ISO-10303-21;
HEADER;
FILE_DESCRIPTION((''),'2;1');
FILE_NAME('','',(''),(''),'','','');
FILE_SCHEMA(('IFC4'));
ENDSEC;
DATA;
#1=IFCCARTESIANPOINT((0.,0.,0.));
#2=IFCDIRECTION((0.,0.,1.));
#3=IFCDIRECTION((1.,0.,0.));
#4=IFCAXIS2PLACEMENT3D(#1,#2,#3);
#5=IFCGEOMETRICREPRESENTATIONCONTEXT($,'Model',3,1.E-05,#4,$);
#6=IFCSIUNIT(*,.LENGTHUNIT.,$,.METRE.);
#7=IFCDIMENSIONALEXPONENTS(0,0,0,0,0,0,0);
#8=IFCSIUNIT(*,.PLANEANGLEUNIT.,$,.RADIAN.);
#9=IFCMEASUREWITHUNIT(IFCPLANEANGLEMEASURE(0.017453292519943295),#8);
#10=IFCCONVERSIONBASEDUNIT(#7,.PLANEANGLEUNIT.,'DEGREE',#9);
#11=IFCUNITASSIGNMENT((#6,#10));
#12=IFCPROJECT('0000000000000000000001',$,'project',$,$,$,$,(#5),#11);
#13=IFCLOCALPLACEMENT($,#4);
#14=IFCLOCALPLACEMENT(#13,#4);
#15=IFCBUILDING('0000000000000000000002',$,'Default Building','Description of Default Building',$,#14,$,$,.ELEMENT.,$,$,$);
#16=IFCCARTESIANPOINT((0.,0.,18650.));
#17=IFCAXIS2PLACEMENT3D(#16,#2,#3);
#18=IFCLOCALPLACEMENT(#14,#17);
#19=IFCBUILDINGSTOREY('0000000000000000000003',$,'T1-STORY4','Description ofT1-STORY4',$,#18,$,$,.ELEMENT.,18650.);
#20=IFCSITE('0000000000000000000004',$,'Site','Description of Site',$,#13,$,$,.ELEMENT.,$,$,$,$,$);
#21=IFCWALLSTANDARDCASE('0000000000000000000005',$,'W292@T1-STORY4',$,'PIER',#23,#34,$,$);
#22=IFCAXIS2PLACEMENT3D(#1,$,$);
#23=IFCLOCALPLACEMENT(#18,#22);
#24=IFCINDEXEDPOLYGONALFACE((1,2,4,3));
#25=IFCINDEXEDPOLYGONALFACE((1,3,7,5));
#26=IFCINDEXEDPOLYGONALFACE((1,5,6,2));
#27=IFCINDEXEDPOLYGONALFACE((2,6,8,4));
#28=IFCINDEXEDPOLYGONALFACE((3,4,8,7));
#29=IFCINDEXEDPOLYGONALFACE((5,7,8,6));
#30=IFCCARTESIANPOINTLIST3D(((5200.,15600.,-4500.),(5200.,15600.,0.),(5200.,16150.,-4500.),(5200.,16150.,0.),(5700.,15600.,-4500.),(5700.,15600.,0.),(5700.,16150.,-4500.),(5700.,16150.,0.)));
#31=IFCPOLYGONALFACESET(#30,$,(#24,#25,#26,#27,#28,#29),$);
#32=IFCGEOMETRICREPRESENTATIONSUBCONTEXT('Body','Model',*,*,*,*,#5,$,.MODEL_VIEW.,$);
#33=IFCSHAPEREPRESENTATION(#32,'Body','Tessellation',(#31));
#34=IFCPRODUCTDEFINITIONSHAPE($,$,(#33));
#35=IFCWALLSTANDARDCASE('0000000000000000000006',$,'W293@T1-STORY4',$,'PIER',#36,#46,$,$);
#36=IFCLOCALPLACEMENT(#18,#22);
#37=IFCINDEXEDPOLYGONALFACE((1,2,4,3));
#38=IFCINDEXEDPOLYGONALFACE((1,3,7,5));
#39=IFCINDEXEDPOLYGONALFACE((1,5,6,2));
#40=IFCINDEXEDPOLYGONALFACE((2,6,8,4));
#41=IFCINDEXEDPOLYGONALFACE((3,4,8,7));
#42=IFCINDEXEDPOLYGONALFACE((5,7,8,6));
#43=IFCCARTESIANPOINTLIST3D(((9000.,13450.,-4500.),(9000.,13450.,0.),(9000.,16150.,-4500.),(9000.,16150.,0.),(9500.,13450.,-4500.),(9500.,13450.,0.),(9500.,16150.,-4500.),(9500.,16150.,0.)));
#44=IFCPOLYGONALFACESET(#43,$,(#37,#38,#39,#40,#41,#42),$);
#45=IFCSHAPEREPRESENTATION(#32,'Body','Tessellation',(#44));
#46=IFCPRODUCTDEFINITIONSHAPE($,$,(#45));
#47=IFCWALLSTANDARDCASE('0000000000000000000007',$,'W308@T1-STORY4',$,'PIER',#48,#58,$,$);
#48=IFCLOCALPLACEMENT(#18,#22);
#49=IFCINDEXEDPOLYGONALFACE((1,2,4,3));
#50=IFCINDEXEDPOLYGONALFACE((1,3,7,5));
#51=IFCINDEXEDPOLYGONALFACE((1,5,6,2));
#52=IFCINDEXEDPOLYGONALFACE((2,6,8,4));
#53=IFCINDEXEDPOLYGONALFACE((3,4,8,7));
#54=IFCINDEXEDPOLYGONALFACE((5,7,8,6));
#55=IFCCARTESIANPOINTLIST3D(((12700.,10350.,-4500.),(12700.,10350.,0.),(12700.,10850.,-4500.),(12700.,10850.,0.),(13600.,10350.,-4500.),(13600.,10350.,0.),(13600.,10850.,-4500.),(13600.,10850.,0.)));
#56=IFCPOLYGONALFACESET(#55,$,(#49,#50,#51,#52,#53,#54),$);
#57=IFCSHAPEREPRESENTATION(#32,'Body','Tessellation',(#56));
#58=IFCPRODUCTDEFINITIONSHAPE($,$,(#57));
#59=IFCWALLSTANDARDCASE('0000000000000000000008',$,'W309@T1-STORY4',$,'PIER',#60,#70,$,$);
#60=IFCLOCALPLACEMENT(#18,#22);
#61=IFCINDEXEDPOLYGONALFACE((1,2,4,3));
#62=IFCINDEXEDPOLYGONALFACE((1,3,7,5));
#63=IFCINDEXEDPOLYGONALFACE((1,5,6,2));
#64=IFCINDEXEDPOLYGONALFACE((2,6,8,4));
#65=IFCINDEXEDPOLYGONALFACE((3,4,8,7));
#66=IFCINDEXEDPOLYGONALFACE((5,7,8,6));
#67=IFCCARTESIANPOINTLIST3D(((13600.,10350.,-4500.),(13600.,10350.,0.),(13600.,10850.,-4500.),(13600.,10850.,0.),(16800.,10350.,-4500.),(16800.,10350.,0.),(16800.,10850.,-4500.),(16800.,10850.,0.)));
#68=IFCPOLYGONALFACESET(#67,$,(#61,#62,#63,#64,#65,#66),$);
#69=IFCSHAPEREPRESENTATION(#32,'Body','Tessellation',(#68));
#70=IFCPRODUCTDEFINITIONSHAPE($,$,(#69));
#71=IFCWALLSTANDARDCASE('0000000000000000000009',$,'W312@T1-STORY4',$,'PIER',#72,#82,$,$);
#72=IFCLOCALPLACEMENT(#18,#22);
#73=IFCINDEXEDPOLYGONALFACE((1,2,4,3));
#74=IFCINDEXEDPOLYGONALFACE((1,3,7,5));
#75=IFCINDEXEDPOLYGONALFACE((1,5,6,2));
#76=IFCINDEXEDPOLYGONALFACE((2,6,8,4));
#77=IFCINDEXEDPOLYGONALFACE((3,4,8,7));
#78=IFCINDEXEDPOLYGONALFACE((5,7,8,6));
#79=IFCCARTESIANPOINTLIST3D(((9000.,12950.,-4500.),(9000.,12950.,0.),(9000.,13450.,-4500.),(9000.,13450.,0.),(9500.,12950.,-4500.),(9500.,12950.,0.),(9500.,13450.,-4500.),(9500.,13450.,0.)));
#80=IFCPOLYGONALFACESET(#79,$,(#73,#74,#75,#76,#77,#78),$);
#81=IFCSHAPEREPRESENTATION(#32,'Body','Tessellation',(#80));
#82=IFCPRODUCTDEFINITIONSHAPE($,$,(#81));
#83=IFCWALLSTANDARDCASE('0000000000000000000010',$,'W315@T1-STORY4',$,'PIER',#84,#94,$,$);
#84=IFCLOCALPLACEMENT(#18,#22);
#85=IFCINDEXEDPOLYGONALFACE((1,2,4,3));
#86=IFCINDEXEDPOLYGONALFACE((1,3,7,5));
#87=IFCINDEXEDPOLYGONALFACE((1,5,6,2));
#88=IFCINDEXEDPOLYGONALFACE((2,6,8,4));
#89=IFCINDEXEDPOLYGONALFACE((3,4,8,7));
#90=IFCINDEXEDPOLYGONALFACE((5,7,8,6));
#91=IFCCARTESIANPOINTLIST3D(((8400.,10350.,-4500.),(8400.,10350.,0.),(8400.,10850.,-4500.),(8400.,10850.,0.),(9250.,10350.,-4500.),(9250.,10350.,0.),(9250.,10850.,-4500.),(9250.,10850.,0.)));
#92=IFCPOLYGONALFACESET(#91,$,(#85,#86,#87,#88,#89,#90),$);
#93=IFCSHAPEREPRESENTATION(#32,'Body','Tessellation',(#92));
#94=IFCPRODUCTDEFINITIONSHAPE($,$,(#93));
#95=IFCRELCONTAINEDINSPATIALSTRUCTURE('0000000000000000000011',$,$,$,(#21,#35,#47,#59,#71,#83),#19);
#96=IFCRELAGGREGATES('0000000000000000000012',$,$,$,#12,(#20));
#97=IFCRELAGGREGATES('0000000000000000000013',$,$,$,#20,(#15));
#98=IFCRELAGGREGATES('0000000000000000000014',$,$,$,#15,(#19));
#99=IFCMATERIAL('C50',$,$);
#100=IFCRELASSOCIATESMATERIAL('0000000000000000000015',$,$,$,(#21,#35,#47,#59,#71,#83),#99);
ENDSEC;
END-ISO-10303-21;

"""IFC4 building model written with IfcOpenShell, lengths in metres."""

from ifc_helpers import new_model, entity, si_unit, converted_unit, frame, origin_with_axes, place, context, subcontext, project, spatial, indexed_curve, outline, extrude, material, element, save


model = new_model("IFC4")

# Units and contexts
model_context = context("Model", 3, precision=1e-05, world=origin_with_axes())
body_context = subcontext(model_context, "Body", "Model", "MODEL_VIEW")
ifc_project = project(units=[si_unit("LENGTHUNIT", "METRE"), converted_unit("PLANEANGLEUNIT", "DEGREE", entity("IfcPlaneAngleMeasure", 0.017453292519943295), si_unit("PLANEANGLEUNIT", "RADIAN"), dimensions=[0, 0, 0, 0, 0, 0, 0])], contexts=[model_context])

# Site, building, storey
site_placement = place(None, origin_with_axes())
site = spatial("IfcSite", under=ifc_project, at=site_placement, Name="Site", Description="Description of Site", CompositionType="ELEMENT")
building_placement = place(site_placement, origin_with_axes())
building = spatial("IfcBuilding", under=site, at=building_placement, Name="Default Building", Description="Description of Default Building", CompositionType="ELEMENT")
storey_placement = place(building_placement, frame((0.0, 0.0, 18650.0), z_axis=(0.0, 0.0, 1.0), x_axis=(1.0, 0.0, 0.0)))
storey = spatial("IfcBuildingStorey", under=building, at=storey_placement, Name="T1-STORY4", Description="Description ofT1-STORY4", CompositionType="ELEMENT", Elevation=18650.0)

# Shared definitions
ifc_material_1 = material(Name="C50")

# Walls
for number, where, z_axis, x_axis, name in (
    (1, (5450.0, 15600.0, -4500.0), (0.0, 0.0, 1.0), (0.0, 1.0, 0.0), "W292@T1-STORY4"),
):
    element("IfcWallStandardCase", number, at=place(storey_placement, frame(where, z_axis=z_axis, x_axis=x_axis)), inside=storey, material=ifc_material_1, Name=name, ObjectType="PIER", context=body_context, shape_type="SweptSolid", body=[
        extrude(outline(indexed_curve([(0.0, -250.0), (0.0, 250.0), (550.0, 250.0), (550.0, -250.0), (0.0, -250.0)], self_intersect=False)), origin_with_axes(), (0.0, 0.0, 1.0), 4500.0),
    ])
wall_1_placement = place(storey_placement, frame((9250.0, 13450.0, -4500.0), z_axis=(0.0, 0.0, 1.0), x_axis=(0.0, 1.0, 0.0)))
element("IfcWallStandardCase", 2, at=wall_1_placement, inside=storey, material=ifc_material_1, Name="W293@T1-STORY4", ObjectType="PIER", context=body_context, shape_type="SweptSolid", body=[
    extrude(outline(indexed_curve([(0.0, -250.0), (0.0, 250.0), (2700.0, 250.0), (2700.0, -250.0), (0.0, -250.0)], self_intersect=False)), origin_with_axes(), (0.0, 0.0, 1.0), 4500.0),
])
wall_2_placement = place(storey_placement, frame((12700.0, 10600.0, -4500.0), z_axis=(0.0, 0.0, 1.0), x_axis=(1.0, 0.0, 0.0)))
element("IfcWallStandardCase", 3, at=wall_2_placement, inside=storey, material=ifc_material_1, Name="W308@T1-STORY4", ObjectType="PIER", context=body_context, shape_type="SweptSolid", body=[
    extrude(outline(indexed_curve([(0.0, -250.0), (0.0, 250.0), (900.0, 250.0), (900.0, -250.0), (0.0, -250.0)], self_intersect=False)), origin_with_axes(), (0.0, 0.0, 1.0), 4500.0),
])
wall_3_placement = place(storey_placement, frame((13600.0, 10600.0, -4500.0), z_axis=(0.0, 0.0, 1.0), x_axis=(1.0, 0.0, 0.0)))
element("IfcWallStandardCase", 4, at=wall_3_placement, inside=storey, material=ifc_material_1, Name="W309@T1-STORY4", ObjectType="PIER", context=body_context, shape_type="SweptSolid", body=[
    extrude(outline(indexed_curve([(0.0, -250.0), (0.0, 250.0), (3200.0, 250.0), (3200.0, -250.0), (0.0, -250.0)], self_intersect=False)), origin_with_axes(), (0.0, 0.0, 1.0), 4500.0),
])
wall_4_placement = place(storey_placement, frame((9250.0, 12950.0, -4500.0), z_axis=(0.0, 0.0, 1.0), x_axis=(0.0, 1.0, 0.0)))
element("IfcWallStandardCase", 5, at=wall_4_placement, inside=storey, material=ifc_material_1, Name="W312@T1-STORY4", ObjectType="PIER", context=body_context, shape_type="SweptSolid", body=[
    extrude(outline(indexed_curve([(0.0, -250.0), (0.0, 250.0), (500.0, 250.0), (500.0, -250.0), (0.0, -250.0)], self_intersect=False)), origin_with_axes(), (0.0, 0.0, 1.0), 4500.0),
])
wall_5_placement = place(storey_placement, frame((8400.0, 10600.0, -4500.0), z_axis=(0.0, 0.0, 1.0), x_axis=(1.0, 0.0, 0.0)))
element("IfcWallStandardCase", 6, at=wall_5_placement, inside=storey, material=ifc_material_1, Name="W315@T1-STORY4", ObjectType="PIER", context=body_context, shape_type="SweptSolid", body=[
    extrude(outline(indexed_curve([(0.0, -250.0), (0.0, 250.0), (850.0, 250.0), (850.0, -250.0), (0.0, -250.0)], self_intersect=False)), origin_with_axes(), (0.0, 0.0, 1.0), 4500.0),
])

save(model, "model.ifc")
